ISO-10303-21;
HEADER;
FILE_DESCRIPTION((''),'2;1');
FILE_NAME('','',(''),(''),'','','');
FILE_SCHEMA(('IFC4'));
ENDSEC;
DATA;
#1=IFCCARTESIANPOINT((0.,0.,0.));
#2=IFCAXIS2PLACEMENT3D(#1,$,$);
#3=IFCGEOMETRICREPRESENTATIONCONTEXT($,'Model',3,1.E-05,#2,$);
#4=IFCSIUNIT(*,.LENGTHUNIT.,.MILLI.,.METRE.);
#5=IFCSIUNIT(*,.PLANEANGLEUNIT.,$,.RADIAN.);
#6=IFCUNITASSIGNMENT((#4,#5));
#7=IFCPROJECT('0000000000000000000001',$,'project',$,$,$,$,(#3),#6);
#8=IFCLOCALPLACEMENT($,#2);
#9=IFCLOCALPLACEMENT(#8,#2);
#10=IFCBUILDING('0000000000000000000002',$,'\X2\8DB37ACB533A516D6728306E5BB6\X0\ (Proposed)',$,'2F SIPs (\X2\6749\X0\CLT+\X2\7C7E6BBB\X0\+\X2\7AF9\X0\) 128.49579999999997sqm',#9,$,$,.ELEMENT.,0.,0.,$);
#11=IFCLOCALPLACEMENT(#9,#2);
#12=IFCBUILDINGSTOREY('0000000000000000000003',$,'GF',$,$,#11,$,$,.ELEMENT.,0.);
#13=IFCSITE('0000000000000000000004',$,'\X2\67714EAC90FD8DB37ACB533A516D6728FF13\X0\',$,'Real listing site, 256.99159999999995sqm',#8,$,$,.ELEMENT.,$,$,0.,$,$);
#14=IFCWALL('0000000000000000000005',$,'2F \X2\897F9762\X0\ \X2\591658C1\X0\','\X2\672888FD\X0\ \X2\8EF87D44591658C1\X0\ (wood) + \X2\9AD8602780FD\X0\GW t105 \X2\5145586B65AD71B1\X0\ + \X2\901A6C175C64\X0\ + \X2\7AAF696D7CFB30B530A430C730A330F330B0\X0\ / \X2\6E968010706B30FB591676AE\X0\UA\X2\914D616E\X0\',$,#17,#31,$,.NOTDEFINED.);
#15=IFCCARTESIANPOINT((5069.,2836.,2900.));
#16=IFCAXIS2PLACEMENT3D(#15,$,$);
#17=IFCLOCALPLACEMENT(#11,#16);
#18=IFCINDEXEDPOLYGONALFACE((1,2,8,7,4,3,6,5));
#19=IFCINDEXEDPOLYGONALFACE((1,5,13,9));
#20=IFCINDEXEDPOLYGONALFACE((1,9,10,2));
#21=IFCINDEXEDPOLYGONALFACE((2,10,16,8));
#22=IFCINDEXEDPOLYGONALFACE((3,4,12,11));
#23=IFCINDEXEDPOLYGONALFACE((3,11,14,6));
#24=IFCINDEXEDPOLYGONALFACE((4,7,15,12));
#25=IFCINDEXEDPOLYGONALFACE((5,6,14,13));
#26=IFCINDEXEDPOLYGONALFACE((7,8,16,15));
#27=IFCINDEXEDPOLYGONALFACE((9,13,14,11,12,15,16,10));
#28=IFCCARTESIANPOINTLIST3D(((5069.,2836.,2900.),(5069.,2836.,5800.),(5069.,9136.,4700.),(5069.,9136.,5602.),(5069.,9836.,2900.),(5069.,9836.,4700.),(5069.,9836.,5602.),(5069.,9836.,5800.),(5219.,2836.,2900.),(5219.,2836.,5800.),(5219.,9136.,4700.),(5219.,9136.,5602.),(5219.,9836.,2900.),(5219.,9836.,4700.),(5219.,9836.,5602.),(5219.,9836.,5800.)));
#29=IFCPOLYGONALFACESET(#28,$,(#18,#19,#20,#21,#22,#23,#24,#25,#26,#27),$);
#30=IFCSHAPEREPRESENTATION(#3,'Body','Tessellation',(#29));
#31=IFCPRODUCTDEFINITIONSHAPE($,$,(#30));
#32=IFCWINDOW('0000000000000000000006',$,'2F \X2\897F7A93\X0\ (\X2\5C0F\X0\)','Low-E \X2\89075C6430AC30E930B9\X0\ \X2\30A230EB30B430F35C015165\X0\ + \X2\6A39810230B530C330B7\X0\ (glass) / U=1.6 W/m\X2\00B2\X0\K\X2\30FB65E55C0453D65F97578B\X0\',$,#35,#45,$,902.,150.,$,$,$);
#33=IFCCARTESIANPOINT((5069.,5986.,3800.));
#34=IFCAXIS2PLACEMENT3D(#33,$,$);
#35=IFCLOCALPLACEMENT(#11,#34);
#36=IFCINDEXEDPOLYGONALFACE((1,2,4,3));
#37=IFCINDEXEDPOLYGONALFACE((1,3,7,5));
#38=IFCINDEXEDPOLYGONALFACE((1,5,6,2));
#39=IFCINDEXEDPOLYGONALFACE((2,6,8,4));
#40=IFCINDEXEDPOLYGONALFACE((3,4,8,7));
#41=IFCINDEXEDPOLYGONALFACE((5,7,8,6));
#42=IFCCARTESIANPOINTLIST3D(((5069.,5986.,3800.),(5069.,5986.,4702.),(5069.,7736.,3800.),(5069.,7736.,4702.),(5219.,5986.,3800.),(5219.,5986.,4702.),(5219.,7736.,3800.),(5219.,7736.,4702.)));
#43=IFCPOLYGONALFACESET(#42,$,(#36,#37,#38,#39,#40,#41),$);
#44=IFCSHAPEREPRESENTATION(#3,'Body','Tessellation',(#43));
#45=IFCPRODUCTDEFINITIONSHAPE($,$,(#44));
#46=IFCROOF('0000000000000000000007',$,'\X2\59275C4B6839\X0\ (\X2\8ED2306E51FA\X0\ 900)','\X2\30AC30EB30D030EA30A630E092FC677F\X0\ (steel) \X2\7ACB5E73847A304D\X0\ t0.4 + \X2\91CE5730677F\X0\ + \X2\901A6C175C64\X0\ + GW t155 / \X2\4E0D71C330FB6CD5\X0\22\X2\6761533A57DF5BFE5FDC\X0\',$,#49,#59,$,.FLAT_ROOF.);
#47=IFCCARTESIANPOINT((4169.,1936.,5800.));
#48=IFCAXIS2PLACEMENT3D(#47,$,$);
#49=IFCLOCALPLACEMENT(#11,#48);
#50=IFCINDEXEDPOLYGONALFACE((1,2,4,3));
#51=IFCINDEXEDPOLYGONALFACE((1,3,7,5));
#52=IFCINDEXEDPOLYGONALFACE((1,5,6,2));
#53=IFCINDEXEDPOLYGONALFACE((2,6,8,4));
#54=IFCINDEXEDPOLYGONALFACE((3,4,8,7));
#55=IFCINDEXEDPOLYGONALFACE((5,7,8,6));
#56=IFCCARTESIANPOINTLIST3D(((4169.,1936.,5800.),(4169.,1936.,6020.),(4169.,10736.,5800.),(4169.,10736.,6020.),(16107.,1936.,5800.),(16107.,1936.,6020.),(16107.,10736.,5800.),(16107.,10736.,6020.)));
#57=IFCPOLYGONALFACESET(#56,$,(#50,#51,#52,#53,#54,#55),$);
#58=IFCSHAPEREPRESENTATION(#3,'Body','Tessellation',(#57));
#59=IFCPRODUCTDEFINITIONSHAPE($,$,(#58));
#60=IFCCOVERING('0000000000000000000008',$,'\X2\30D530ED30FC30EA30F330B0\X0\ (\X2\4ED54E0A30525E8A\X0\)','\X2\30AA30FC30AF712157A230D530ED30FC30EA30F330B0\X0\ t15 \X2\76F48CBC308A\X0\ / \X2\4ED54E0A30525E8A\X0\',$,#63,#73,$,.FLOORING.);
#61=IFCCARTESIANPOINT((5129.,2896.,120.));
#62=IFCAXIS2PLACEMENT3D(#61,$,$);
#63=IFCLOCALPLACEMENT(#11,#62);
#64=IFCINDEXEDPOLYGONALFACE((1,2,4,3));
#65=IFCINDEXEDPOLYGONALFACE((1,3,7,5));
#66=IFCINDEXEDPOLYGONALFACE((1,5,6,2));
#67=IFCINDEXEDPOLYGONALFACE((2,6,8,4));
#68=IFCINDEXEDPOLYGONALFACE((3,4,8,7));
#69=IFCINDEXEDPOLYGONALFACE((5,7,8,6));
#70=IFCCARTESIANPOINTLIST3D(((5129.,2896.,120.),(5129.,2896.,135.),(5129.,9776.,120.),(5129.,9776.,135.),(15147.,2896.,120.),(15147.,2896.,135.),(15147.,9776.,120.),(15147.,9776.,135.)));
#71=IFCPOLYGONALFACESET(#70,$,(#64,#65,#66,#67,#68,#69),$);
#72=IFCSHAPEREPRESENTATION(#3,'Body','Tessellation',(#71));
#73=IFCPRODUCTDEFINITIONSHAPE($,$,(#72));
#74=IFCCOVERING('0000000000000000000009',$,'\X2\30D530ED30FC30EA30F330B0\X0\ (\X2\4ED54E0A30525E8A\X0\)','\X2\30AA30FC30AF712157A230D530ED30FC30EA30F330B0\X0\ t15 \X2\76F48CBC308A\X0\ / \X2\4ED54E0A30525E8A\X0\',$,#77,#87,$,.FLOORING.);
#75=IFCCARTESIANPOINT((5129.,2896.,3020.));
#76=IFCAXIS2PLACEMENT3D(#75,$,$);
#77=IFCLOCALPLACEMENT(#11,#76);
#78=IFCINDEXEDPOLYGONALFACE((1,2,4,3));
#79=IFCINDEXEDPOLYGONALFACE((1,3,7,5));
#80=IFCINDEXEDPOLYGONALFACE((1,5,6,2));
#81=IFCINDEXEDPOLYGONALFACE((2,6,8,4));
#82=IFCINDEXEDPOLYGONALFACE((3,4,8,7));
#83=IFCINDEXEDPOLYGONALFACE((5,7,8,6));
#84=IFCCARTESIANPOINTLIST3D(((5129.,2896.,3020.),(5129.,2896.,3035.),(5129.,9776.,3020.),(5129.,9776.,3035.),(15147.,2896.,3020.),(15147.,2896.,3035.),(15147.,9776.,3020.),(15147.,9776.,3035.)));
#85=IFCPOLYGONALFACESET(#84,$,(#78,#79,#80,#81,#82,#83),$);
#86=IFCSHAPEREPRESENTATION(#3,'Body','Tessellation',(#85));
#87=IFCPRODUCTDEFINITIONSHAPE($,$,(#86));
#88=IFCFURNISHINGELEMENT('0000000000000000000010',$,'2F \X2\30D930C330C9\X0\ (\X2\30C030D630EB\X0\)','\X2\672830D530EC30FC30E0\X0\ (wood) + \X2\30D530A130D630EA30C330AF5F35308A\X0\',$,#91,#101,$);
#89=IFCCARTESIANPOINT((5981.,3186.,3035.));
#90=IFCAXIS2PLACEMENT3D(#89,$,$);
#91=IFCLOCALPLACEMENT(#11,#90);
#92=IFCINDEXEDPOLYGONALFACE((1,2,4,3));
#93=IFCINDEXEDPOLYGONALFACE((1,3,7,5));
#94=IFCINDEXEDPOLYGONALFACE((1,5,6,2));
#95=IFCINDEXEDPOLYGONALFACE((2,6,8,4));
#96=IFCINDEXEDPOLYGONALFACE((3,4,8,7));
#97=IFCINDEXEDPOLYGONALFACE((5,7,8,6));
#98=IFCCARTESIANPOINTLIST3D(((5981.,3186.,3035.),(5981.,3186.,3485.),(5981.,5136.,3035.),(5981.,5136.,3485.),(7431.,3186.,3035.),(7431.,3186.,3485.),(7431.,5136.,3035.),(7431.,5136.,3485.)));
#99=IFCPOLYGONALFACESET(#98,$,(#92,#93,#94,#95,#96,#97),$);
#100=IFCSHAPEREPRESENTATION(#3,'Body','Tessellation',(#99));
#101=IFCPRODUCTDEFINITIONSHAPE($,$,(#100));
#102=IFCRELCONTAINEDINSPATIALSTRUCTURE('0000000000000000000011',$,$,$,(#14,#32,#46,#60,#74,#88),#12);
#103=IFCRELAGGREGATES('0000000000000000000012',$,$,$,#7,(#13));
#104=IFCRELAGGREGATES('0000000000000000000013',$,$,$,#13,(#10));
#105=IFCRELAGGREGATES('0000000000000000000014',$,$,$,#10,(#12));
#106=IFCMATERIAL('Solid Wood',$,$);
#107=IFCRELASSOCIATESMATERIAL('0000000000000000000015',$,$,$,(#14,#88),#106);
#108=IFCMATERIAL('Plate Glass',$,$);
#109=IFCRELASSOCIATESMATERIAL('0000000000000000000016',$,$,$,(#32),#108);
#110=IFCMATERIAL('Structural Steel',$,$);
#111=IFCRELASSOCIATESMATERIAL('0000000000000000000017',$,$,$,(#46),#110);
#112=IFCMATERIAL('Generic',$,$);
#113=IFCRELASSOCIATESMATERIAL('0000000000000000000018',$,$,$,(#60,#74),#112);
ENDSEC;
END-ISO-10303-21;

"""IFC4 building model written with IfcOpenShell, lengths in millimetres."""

from ifc_helpers import new_model, si_unit, frame, frame_2d, origin, place, context, project, spatial, rectangle, extrude, material, element, fill, save


model = new_model("IFC4")

# Units and contexts
model_context = context("Model", 3, precision=1e-05, world=origin())
ifc_project = project(units=[si_unit("LENGTHUNIT", "METRE", prefix="MILLI"), si_unit("PLANEANGLEUNIT", "RADIAN")], contexts=[model_context])

# Site, building, storey
site_placement = place(None, origin())
site = spatial("IfcSite", under=ifc_project, at=site_placement, Name="東京都足立区六木３", ObjectType="Real listing site, 256.99159999999995sqm", CompositionType="ELEMENT", RefElevation=0.0)
building_placement = place(site_placement, origin())
building = spatial("IfcBuilding", under=site, at=building_placement, Name="足立区六木の家 (Proposed)", ObjectType="2F SIPs (杉CLT+籾殻+竹) 128.49579999999997sqm", CompositionType="ELEMENT", ElevationOfRefHeight=0.0, ElevationOfTerrain=0.0)
storey_placement = place(building_placement, origin())
storey = spatial("IfcBuildingStorey", under=building, at=storey_placement, Name="GF", CompositionType="ELEMENT", Elevation=0.0)

# Shared definitions
ifc_material_1 = material(Name="Solid Wood")

# Shared definitions
ifc_material_2 = material(Name="Plate Glass")

# Wall, opening, window
wall_1_placement = place(storey_placement, frame((5069.0, 2836.0, 2900.0)))
wall_1 = element("IfcWall", 1, at=wall_1_placement, inside=storey, material=ifc_material_1, Name="2F 西面 外壁", Description="木製 軸組外壁 (wood) + 高性能GW t105 充填断熱 + 通気層 + 窯業系サイディング / 準耐火・外皮UA配慮", PredefinedType="NOTDEFINED", context=model_context, shape_type="SweptSolid", body=[
    extrude(rectangle(XDim=150.0, YDim=7000.0, at=frame_2d((75.0, 3500.0))), frame((5069.0, 2836.0, 2900.0)), (0.0, 0.0, 1.0), 2900.0),
])
opening_1_placement = place(storey_placement, frame((5069.0, 5986.0, 3800.0)))
opening_1 = element("IfcOpeningElement", 2, at=opening_1_placement, cuts=wall_1, PredefinedType="NOTDEFINED", context=model_context, shape_type="SweptSolid", body=[
    extrude(rectangle(XDim=150.0, YDim=1750.0, at=frame_2d((75.0, 875.0))), frame((5069.0, 5986.0, 3800.0)), (0.0, 0.0, 1.0), 902.0),
])
window_1_placement = place(storey_placement, frame((5069.0, 5986.0, 3800.0)))
window_1 = element("IfcWindow", 3, at=window_1_placement, inside=storey, material=ifc_material_2, Name="2F 西窓 (小)", Description="Low-E 複層ガラス アルゴン封入 + 樹脂サッシ (glass) / U=1.6 W/m²K・日射取得型", OverallHeight=902.0, OverallWidth=150.0, context=model_context, shape_type="SweptSolid", body=[
    extrude(rectangle(XDim=150.0, YDim=1750.0, at=frame_2d((75.0, 875.0))), frame((5069.0, 5986.0, 3800.0)), (0.0, 0.0, 1.0), 902.0),
])
fill(opening_1, window_1)

# Roof
ifc_material_3 = material(Name="Structural Steel")
roof_placement = place(storey_placement, frame((4169.0, 1936.0, 5800.0)))
element("IfcRoof", 4, at=roof_placement, inside=storey, material=ifc_material_3, Name="大屋根 (軒の出 900)", Description="ガルバリウム鋼板 (steel) 立平葺き t0.4 + 野地板 + 通気層 + GW t155 / 不燃・法22条区域対応", PredefinedType="FLAT_ROOF", context=model_context, shape_type="SweptSolid", body=[
    extrude(rectangle(XDim=11938.0, YDim=8800.0, at=frame_2d((5969.0, 4400.0))), frame((4169.0, 1936.0, 5800.0)), (0.0, 0.0, 1.0), 220.0),
])

# Coverings
ifc_material_4 = material(Name="Generic")
covering_1_placement = place(storey_placement, frame((5129.0, 2896.0, 120.0)))
element("IfcCovering", 5, at=covering_1_placement, inside=storey, material=ifc_material_4, Name="フローリング (仕上げ床)", Description="オーク無垢フローリング t15 直貼り / 仕上げ床", PredefinedType="FLOORING", context=model_context, shape_type="SweptSolid", body=[
    extrude(rectangle(XDim=10018.0, YDim=6880.0, at=frame_2d((5009.0, 3440.0))), frame((5129.0, 2896.0, 120.0)), (0.0, 0.0, 1.0), 15.0),
])
covering_2_placement = place(storey_placement, frame((5129.0, 2896.0, 3020.0)))
element("IfcCovering", 6, at=covering_2_placement, inside=storey, material=ifc_material_4, Name="フローリング (仕上げ床)", Description="オーク無垢フローリング t15 直貼り / 仕上げ床", PredefinedType="FLOORING", context=model_context, shape_type="SweptSolid", body=[
    extrude(rectangle(XDim=10018.0, YDim=6880.0, at=frame_2d((5009.0, 3440.0))), frame((5129.0, 2896.0, 3020.0)), (0.0, 0.0, 1.0), 15.0),
])

# Furnishing element
furnishing_placement = place(storey_placement, frame((5981.0, 3186.0, 3035.0)))
element("IfcFurnishingElement", 7, at=furnishing_placement, inside=storey, material=ifc_material_1, Name="2F ベッド (ダブル)", Description="木フレーム (wood) + ファブリック張り", context=model_context, shape_type="SweptSolid", body=[
    extrude(rectangle(XDim=1450.0, YDim=1950.0, at=frame_2d((725.0, 975.0))), frame((5981.0, 3186.0, 3035.0)), (0.0, 0.0, 1.0), 450.0),
])

save(model, "model.ifc")
